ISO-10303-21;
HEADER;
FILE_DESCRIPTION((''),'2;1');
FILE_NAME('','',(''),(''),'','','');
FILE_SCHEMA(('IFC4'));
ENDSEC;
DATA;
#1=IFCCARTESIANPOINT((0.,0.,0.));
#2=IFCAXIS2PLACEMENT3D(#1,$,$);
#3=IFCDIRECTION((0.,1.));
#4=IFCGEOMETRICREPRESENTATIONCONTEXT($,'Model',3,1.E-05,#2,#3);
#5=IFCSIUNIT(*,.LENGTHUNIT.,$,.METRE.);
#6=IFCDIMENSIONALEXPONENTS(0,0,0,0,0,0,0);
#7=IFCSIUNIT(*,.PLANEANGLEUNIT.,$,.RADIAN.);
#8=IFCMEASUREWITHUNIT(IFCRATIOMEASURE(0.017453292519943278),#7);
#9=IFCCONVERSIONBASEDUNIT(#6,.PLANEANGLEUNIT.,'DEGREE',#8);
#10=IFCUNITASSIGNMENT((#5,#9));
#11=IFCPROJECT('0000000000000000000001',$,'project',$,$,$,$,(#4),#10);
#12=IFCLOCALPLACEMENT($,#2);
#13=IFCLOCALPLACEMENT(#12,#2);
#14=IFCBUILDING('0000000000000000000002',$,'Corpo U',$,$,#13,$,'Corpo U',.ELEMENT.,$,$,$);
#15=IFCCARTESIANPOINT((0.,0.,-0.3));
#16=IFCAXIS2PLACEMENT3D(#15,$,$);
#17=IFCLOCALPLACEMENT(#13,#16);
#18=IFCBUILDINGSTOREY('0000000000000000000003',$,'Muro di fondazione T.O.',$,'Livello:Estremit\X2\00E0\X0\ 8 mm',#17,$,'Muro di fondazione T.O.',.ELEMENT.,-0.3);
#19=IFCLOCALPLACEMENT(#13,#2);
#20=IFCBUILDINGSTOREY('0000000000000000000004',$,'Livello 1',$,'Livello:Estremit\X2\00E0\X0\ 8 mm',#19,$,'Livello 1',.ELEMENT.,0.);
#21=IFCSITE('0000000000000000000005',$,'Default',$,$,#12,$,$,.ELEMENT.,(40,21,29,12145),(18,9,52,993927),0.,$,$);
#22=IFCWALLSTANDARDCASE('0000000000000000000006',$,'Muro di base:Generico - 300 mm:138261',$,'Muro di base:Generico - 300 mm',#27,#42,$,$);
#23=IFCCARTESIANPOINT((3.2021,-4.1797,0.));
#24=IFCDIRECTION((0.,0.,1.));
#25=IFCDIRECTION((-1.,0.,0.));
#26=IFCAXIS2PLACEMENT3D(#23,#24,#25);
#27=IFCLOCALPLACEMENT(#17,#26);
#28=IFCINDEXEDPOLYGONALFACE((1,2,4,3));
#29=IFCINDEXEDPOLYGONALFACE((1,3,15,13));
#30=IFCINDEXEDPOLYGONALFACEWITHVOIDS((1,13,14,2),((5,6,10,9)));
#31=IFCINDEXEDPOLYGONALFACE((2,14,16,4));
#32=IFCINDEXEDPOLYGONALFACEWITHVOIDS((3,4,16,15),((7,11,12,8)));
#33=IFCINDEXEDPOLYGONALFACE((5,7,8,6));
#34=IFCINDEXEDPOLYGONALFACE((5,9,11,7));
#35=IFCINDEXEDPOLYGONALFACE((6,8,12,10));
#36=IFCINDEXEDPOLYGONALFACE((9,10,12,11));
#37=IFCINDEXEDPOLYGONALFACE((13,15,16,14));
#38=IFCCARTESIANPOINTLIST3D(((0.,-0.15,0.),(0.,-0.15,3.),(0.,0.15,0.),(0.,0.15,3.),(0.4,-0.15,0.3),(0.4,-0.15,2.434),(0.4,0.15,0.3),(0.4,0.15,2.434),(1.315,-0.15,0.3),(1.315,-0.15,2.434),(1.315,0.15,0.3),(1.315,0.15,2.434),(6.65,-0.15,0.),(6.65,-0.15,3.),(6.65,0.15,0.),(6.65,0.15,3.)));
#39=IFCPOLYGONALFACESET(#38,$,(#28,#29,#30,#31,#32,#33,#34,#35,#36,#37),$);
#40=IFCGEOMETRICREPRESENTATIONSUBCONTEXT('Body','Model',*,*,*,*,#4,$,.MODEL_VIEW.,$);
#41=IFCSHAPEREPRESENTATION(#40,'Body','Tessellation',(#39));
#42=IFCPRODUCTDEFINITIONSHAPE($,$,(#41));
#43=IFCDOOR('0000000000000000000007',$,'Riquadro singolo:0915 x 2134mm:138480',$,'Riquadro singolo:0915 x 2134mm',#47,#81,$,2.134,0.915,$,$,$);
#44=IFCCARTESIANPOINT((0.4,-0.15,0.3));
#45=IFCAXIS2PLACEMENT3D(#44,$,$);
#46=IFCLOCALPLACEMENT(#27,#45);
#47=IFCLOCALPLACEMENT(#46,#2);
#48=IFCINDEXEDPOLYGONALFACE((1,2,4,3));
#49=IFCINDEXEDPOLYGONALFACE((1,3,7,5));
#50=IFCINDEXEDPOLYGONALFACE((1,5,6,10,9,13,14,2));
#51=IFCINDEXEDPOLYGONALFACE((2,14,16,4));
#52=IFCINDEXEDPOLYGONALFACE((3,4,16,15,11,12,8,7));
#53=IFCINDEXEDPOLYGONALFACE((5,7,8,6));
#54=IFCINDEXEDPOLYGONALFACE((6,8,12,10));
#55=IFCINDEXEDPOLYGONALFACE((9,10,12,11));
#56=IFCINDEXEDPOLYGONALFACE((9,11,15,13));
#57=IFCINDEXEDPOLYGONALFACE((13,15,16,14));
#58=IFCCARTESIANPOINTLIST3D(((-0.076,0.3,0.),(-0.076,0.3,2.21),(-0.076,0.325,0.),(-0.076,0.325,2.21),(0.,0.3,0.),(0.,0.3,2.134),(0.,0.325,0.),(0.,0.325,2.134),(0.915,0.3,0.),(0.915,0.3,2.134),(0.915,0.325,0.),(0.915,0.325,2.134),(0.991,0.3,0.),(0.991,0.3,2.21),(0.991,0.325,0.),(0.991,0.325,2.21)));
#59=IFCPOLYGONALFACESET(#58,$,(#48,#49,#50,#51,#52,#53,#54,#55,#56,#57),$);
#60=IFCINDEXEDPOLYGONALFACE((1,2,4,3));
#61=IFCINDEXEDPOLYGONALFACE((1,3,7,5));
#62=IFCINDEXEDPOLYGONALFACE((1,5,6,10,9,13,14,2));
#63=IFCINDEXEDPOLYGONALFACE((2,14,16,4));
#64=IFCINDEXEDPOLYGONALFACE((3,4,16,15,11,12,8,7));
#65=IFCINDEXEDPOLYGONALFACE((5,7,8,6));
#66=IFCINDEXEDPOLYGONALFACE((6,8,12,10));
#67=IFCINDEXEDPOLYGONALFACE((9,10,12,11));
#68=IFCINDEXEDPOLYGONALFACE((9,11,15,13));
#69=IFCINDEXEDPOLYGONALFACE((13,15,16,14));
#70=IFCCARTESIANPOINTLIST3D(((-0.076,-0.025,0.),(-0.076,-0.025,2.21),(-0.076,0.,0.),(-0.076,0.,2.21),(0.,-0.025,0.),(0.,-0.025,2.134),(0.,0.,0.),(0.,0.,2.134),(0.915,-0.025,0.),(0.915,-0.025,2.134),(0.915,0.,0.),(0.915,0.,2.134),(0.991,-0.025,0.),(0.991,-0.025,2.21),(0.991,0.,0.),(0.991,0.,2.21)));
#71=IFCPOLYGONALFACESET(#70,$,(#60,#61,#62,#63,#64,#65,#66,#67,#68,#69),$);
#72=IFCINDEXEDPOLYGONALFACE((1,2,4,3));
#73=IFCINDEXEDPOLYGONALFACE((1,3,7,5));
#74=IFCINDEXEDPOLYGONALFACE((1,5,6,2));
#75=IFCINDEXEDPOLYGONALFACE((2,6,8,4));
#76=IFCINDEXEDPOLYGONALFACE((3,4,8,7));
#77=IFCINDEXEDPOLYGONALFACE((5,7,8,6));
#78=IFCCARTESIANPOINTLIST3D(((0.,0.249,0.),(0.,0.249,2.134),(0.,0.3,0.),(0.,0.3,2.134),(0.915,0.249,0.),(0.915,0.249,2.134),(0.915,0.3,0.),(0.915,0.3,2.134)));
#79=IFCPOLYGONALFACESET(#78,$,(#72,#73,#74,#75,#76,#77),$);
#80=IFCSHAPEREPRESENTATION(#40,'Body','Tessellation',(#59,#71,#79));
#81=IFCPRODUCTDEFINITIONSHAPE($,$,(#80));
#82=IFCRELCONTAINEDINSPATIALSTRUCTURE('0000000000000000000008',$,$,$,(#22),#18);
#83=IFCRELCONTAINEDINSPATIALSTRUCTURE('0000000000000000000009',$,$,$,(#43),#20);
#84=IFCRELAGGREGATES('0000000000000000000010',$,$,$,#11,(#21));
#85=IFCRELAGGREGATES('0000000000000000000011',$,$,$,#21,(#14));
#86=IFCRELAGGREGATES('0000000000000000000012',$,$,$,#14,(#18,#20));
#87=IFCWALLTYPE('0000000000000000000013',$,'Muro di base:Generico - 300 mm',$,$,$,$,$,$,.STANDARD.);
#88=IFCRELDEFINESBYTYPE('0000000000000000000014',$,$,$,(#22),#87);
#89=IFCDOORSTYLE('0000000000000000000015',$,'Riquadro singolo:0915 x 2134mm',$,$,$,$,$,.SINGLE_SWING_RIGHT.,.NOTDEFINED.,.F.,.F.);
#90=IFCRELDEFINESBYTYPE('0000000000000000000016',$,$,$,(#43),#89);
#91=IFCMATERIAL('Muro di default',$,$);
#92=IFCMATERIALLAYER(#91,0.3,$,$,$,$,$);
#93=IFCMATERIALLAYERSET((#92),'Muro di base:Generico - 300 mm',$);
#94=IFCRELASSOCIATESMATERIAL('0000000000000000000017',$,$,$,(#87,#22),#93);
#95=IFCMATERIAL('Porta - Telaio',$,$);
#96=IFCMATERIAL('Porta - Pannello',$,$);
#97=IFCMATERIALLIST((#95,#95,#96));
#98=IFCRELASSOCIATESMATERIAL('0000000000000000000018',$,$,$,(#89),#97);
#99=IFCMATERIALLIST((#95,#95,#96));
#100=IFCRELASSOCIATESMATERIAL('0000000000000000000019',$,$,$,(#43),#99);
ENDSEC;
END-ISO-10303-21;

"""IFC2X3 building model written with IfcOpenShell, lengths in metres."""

from ifc_helpers import new_model, entity, si_unit, converted_unit, direction, frame, frame_2d, origin, place, context, subcontext, project, spatial, polyline, rectangle, outline, extrude, source, transform, mapped, material, material_list, layer, layer_set, layer_usage, type_object, type_shapes, element, fill, save


model = new_model("IFC2X3")

# Units and contexts
model_context = context("Model", 3, precision=1e-05, world=origin(), true_north=direction((0.0, 1.0)))
body_context = subcontext(model_context, "Body", "Model", "MODEL_VIEW")
ifc_project = project(units=[si_unit("LENGTHUNIT", "METRE"), converted_unit("PLANEANGLEUNIT", "DEGREE", entity("IfcRatioMeasure", 0.017453292519943278), si_unit("PLANEANGLEUNIT", "RADIAN"), dimensions=[0, 0, 0, 0, 0, 0, 0])], contexts=[model_context])

# Site, building, storey
site_placement = place(None, origin())
site = spatial("IfcSite", under=ifc_project, at=site_placement, Name="Default", CompositionType="ELEMENT", RefLatitude=(40, 21, 29, 12145), RefLongitude=(18, 9, 52, 993927), RefElevation=0.0)
building_placement = place(site_placement, origin())
building = spatial("IfcBuilding", under=site, at=building_placement, Name="Corpo U", LongName="Corpo U", CompositionType="ELEMENT")
storey_1_placement = place(building_placement, frame((0.0, 0.0, -0.3)))
storey_1 = spatial("IfcBuildingStorey", under=building, at=storey_1_placement, Name="Muro di fondazione T.O.", ObjectType="Livello:Estremità 8 mm", LongName="Muro di fondazione T.O.", CompositionType="ELEMENT", Elevation=-0.3)

# Shared definitions
ifc_material_1 = material(Name="Muro di default")
ifc_layer = layer(ifc_material_1, 0.3)
ifc_layer_set = layer_set([ifc_layer], Name="Muro di base:Generico - 300 mm")
wall_type = type_object("IfcWallType", Name="Muro di base:Generico - 300 mm", PredefinedType="STANDARD", material=ifc_layer_set)

# Shared definitions
storey_2_placement = place(building_placement, origin())
storey_2 = spatial("IfcBuildingStorey", under=building, at=storey_2_placement, Name="Livello 1", ObjectType="Livello:Estremità 8 mm", LongName="Livello 1", CompositionType="ELEMENT", Elevation=0.0)

# Wall, opening, door
ifc_layer_usage_1 = layer_usage(ifc_layer_set, "AXIS2", "NEGATIVE", 0.15)
wall_1_placement = place(storey_1_placement, frame((3.2021, -4.1797, 0.0), z_axis=(0.0, 0.0, 1.0), x_axis=(-1.0, 0.0, 0.0)))
wall_1 = element("IfcWallStandardCase", 1, at=wall_1_placement, inside=storey_1, type_object=wall_type, material=ifc_layer_usage_1, Name="Muro di base:Generico - 300 mm:138261", ObjectType="Muro di base:Generico - 300 mm", context=body_context, shape_type="SweptSolid", body=[
    extrude(rectangle(XDim=6.65, YDim=0.3, at=frame_2d((3.325, 0.0), x_axis=(-1.0, 0.0))), origin(), (0.0, 0.0, 1.0), 3.0),
])
opening_1_placement = place(wall_1_placement, frame((0.4, -0.15, 0.3)))
opening_1 = element("IfcOpeningElement", 2, at=opening_1_placement, cuts=wall_1, ObjectType="Opening", context=body_context, shape_type="SweptSolid", body=[
    extrude(rectangle(XDim=0.915, YDim=2.134, at=frame_2d((1.067, 0.4575), x_axis=(0.0, 1.0))), frame((0.0, 0.0, 0.0), z_axis=(0.0, 1.0, 0.0), x_axis=(0.0, 0.0, 1.0)), (0.0, 0.0, 1.0), 0.3),
])
ifc_material_2 = material(Name="Porta - Telaio")
ifc_material_3 = material(Name="Porta - Pannello")
ifc_material_list_1 = material_list([ifc_material_2, ifc_material_2, ifc_material_3])
ifc_material_list_2 = material_list([ifc_material_2, ifc_material_2, ifc_material_3])
door_style = type_object("IfcDoorStyle", Name="Riquadro singolo:0915 x 2134mm", ConstructionType="NOTDEFINED", OperationType="SINGLE_SWING_RIGHT", ParameterTakesPrecedence=False, Sizeable=False, material=ifc_material_list_2)
shared_shape_1 = source(origin(), body_context, "Body", "SweptSolid", [
    extrude(outline(polyline([(-0.5335, -1.124), (0.5335, -1.124), (0.5335, 1.086), (0.4575, 1.086), (0.4575, -1.048), (-0.4575, -1.048), (-0.4575, 1.086), (-0.5335, 1.086), (-0.5335, -1.124)])), frame((0.4575, 0.3, 1.086), z_axis=(0.0, 1.0, 0.0), x_axis=(1.0, 0.0, 0.0)), (0.0, 0.0, 1.0), 0.025),
    extrude(outline(polyline([(-1.124, -0.5335), (1.086, -0.5335), (1.086, -0.4575), (-1.048, -0.4575), (-1.048, 0.4575), (1.086, 0.4575), (1.086, 0.5335), (-1.124, 0.5335), (-1.124, -0.5335)])), frame((0.4575, -0.025, 1.086), z_axis=(0.0, 1.0, 0.0), x_axis=(0.0, 0.0, -1.0)), (0.0, 0.0, 1.0), 0.025),
    extrude(rectangle(XDim=0.051, YDim=0.915, at=frame_2d((0.0, 0.0), x_axis=(1.0, 0.0))), frame((0.4575, 0.2745, 0.0), z_axis=(0.0, 0.0, 1.0), x_axis=(0.0, 1.0, 0.0)), (0.0, 0.0, 1.0), 2.134),
])
type_shapes(door_style, [shared_shape_1])
door_placement = place(opening_1_placement, origin())
door = element("IfcDoor", 3, at=door_placement, inside=storey_2, type_object=door_style, material=ifc_material_list_1, Name="Riquadro singolo:0915 x 2134mm:138480", ObjectType="Riquadro singolo:0915 x 2134mm", OverallHeight=2.134, OverallWidth=0.915, context=body_context, shape_type="MappedRepresentation", body=[
    mapped(shared_shape_1, transform((0.0, 0.0, 0.0), scale=1.0)),
])
fill(opening_1, door)

save(model, "model.ifc")
